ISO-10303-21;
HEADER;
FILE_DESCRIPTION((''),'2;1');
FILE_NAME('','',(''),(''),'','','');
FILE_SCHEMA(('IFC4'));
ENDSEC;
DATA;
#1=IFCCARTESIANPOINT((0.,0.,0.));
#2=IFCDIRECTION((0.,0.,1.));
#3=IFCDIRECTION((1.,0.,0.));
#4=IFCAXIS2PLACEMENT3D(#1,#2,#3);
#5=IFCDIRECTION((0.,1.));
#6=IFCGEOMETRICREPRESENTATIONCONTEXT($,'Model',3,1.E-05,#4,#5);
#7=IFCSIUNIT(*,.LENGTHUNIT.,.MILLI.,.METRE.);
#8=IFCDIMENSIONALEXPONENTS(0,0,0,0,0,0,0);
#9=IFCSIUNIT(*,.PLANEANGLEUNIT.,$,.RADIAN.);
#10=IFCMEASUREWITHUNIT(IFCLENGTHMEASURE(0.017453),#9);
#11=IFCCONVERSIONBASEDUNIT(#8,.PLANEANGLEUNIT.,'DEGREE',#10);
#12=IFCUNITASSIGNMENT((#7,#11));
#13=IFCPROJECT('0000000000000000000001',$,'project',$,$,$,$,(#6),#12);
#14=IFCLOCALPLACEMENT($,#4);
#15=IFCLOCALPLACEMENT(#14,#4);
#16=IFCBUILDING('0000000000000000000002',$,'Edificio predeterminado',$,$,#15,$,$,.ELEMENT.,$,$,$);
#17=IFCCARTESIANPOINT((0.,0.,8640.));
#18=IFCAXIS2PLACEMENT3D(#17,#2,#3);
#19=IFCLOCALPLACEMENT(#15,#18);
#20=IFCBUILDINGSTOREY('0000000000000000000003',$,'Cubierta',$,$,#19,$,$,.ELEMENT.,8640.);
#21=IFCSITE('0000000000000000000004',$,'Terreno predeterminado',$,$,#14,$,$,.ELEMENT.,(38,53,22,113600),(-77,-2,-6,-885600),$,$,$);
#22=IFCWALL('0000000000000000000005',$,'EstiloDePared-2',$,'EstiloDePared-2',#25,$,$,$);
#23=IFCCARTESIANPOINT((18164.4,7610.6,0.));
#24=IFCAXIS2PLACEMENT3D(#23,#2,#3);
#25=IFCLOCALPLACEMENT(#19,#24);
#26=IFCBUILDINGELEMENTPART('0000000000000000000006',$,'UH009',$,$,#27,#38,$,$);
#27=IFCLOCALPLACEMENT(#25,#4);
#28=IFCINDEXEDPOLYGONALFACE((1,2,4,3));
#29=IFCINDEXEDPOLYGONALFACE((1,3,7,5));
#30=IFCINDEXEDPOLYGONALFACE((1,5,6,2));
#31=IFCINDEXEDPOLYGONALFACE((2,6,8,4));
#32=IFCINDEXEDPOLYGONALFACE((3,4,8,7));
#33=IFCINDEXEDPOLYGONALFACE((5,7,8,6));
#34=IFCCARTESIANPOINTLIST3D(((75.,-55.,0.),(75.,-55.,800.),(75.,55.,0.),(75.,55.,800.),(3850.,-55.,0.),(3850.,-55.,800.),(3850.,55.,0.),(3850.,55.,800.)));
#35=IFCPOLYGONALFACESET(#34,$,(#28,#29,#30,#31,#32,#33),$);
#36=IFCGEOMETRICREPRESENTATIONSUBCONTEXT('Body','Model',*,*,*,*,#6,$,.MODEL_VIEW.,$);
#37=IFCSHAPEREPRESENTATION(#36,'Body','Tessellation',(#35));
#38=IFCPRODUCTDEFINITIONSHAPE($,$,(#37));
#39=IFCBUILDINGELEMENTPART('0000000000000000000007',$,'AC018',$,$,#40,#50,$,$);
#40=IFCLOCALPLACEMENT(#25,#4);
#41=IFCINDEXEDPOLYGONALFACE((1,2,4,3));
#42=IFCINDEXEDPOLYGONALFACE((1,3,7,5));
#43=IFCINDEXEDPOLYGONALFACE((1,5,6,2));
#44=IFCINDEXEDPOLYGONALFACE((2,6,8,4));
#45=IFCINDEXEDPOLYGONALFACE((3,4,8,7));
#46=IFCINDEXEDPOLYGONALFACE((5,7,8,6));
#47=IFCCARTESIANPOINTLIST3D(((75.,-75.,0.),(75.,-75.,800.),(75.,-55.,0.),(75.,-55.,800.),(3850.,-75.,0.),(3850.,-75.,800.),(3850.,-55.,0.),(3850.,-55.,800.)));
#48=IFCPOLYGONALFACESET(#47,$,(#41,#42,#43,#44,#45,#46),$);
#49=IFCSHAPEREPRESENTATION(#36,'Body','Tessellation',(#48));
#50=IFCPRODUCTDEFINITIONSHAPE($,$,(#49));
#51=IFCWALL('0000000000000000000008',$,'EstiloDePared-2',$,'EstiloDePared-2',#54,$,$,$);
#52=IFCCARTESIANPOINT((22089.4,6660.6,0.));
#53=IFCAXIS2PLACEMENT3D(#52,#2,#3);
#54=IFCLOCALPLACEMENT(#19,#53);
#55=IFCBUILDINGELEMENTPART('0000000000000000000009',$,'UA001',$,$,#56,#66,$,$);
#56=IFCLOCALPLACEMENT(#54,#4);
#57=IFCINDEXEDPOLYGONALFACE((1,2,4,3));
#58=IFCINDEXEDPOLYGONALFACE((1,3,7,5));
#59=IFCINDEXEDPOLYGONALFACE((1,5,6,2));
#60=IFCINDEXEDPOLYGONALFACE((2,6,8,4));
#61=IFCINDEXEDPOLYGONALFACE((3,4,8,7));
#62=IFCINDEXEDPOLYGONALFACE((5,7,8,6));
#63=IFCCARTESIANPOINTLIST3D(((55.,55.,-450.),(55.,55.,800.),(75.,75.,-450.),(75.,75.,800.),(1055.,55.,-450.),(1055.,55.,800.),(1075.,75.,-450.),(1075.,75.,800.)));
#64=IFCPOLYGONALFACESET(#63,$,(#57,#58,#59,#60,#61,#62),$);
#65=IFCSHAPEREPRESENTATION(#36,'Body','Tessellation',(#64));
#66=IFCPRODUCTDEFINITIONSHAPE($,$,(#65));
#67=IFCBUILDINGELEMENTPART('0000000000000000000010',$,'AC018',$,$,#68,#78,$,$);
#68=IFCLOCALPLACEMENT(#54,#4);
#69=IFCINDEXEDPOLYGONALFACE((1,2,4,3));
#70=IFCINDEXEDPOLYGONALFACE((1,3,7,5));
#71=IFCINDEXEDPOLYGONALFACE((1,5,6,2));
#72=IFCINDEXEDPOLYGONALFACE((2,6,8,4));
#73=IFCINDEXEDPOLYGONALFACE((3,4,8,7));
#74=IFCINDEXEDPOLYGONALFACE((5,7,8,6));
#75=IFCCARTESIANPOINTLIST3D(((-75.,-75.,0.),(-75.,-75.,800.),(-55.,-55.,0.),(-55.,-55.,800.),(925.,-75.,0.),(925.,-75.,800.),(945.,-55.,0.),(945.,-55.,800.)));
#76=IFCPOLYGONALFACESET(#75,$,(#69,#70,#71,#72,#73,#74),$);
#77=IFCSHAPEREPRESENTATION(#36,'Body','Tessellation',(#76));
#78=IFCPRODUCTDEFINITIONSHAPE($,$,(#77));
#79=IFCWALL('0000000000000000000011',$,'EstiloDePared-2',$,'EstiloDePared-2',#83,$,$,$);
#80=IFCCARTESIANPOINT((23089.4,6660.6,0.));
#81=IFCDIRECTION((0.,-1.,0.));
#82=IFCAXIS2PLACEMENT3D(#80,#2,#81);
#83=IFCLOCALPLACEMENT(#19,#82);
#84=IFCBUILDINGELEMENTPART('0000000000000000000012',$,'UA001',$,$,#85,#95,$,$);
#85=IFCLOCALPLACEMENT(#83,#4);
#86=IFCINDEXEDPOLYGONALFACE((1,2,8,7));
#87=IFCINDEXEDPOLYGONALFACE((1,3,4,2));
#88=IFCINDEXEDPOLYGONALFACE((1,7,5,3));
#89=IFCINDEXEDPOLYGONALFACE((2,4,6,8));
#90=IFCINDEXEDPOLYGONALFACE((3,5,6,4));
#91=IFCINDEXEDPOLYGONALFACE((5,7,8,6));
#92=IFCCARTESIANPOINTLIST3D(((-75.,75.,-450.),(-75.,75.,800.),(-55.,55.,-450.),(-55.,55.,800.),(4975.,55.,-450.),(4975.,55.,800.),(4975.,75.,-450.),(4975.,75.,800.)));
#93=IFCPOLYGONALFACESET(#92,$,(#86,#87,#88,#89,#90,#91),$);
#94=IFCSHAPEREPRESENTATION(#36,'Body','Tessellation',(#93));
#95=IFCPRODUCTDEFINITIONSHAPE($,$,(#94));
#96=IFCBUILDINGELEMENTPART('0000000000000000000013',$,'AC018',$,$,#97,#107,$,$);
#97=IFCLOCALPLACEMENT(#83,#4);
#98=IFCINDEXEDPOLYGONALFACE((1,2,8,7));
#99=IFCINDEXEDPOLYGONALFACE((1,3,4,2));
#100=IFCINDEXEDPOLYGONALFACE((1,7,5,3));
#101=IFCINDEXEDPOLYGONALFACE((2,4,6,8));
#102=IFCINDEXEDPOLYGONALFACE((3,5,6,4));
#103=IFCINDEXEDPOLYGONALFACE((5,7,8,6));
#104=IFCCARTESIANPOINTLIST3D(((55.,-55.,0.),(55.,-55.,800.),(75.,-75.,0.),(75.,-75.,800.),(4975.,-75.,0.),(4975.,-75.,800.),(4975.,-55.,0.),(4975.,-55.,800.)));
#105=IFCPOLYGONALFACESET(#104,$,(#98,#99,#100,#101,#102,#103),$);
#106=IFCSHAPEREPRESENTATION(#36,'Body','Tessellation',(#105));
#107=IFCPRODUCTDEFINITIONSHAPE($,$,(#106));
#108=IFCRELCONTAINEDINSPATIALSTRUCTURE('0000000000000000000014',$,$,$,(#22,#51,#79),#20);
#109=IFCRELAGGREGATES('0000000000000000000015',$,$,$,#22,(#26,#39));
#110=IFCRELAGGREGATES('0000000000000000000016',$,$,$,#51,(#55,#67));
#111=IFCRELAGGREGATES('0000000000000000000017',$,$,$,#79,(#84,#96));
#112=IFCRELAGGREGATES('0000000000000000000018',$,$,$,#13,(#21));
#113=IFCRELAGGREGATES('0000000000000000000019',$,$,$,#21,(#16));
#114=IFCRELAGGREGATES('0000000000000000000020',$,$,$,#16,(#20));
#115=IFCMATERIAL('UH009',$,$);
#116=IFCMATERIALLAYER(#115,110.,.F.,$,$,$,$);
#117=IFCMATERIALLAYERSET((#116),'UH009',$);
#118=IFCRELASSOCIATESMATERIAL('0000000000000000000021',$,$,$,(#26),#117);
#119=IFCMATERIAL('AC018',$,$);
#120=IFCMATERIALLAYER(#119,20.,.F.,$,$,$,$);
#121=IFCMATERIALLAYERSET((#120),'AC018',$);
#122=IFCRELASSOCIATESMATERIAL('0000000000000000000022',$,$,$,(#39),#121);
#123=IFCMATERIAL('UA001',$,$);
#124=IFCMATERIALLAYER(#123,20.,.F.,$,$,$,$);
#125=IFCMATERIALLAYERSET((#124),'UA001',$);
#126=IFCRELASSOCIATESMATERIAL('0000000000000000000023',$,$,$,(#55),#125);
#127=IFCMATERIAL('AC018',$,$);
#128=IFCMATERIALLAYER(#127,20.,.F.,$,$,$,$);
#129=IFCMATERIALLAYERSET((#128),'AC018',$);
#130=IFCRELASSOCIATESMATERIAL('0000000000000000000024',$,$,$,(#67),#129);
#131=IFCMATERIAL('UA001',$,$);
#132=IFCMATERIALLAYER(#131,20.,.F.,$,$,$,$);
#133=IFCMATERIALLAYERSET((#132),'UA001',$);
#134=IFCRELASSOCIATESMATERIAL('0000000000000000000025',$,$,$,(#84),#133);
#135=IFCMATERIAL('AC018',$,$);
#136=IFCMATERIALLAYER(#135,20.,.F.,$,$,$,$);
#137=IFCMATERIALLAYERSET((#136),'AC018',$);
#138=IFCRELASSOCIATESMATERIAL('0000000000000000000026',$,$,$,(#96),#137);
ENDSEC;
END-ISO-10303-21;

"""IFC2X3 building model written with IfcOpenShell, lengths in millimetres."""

from ifc_helpers import new_model, entity, si_unit, converted_unit, direction, frame, origin_with_axes, place, context, subcontext, project, spatial, polyline, outline, extrude, material, layer, layer_set, layer_usage, element, aggregate, save


model = new_model("IFC2X3")

# Units and contexts
model_context = context("Model", 3, precision=1e-05, world=origin_with_axes(), true_north=direction((0.0, 1.0)))
body_context = subcontext(model_context, "Body", "Model", "MODEL_VIEW")
ifc_project = project(units=[si_unit("LENGTHUNIT", "METRE", prefix="MILLI"), converted_unit("PLANEANGLEUNIT", "DEGREE", entity("IfcLengthMeasure", 0.017453), si_unit("PLANEANGLEUNIT", "RADIAN"), dimensions=[0, 0, 0, 0, 0, 0, 0])], contexts=[model_context])

# Site, building, storey
site_placement = place(None, origin_with_axes())
site = spatial("IfcSite", under=ifc_project, at=site_placement, Name="Terreno predeterminado", CompositionType="ELEMENT", RefLatitude=(38, 53, 22, 113600), RefLongitude=(-77, -2, -6, -885600))
building_placement = place(site_placement, origin_with_axes())
building = spatial("IfcBuilding", under=site, at=building_placement, Name="Edificio predeterminado", CompositionType="ELEMENT")
storey_placement = place(building_placement, frame((0.0, 0.0, 8640.0), z_axis=(0.0, 0.0, 1.0), x_axis=(1.0, 0.0, 0.0)))
storey = spatial("IfcBuildingStorey", under=building, at=storey_placement, Name="Cubierta", CompositionType="ELEMENT", Elevation=8640.0)

# Walls, building element parts
wall_1_placement = place(storey_placement, frame((18164.4, 7610.6, 0.0), z_axis=(0.0, 0.0, 1.0), x_axis=(1.0, 0.0, 0.0)))
wall_1 = element("IfcWall", 1, at=wall_1_placement, inside=storey, Name="EstiloDePared-2", ObjectType="EstiloDePared-2")
ifc_material_1 = material(Name="UH009")
ifc_layer_1 = layer(ifc_material_1, 110.0, ventilated=False)
ifc_layer_set_1 = layer_set([ifc_layer_1], Name="UH009")
ifc_layer_usage_1 = layer_usage(ifc_layer_set_1, "AXIS2", "NEGATIVE", -55.0)
building_element_part_1_placement = place(wall_1_placement, origin_with_axes())
building_element_part_1 = element("IfcBuildingElementPart", 2, at=building_element_part_1_placement, material=ifc_layer_usage_1, Name="UH009", context=body_context, shape_type="SweptSolid", body=[
    extrude(outline(polyline([(3850.0, 55.0), (3850.0, -55.0), (75.0, -55.0), (75.0, 55.0), (3850.0, 55.0)])), origin_with_axes(), (0.0, 0.0, 1.0), 800.0),
])
ifc_material_2 = material(Name="AC018")
ifc_layer_2 = layer(ifc_material_2, 20.0, ventilated=False)
ifc_layer_set_2 = layer_set([ifc_layer_2], Name="AC018")
ifc_layer_usage_2 = layer_usage(ifc_layer_set_2, "AXIS2", "NEGATIVE", 55.0)
building_element_part_2_placement = place(wall_1_placement, origin_with_axes())
building_element_part_2 = element("IfcBuildingElementPart", 3, at=building_element_part_2_placement, material=ifc_layer_usage_2, Name="AC018", context=body_context, shape_type="SweptSolid", body=[
    extrude(outline(polyline([(3850.0, -55.0), (3850.0, -75.0), (75.0, -75.0), (75.0, -55.0), (3850.0, -55.0)])), origin_with_axes(), (0.0, 0.0, 1.0), 800.0),
])
aggregate(wall_1, [building_element_part_1, building_element_part_2])
wall_2_placement = place(storey_placement, frame((22089.4, 6660.6, 0.0), z_axis=(0.0, 0.0, 1.0), x_axis=(1.0, 0.0, 0.0)))
wall_2 = element("IfcWall", 4, at=wall_2_placement, inside=storey, Name="EstiloDePared-2", ObjectType="EstiloDePared-2")
ifc_material_3 = material(Name="UA001")
ifc_layer_3 = layer(ifc_material_3, 20.0, ventilated=False)
ifc_layer_set_3 = layer_set([ifc_layer_3], Name="UA001")
ifc_layer_usage_3 = layer_usage(ifc_layer_set_3, "AXIS2", "NEGATIVE", -75.0)
building_element_part_3_placement = place(wall_2_placement, origin_with_axes())
building_element_part_3 = element("IfcBuildingElementPart", 5, at=building_element_part_3_placement, material=ifc_layer_usage_3, Name="UA001", context=body_context, shape_type="SweptSolid", body=[
    extrude(outline(polyline([(1075.0, 75.0), (1055.0, 55.0), (55.0, 55.0), (75.0, 75.0), (1075.0, 75.0)])), frame((0.0, 0.0, -450.0), z_axis=(0.0, 0.0, 1.0), x_axis=(1.0, 0.0, 0.0)), (0.0, 0.0, 1.0), 1250.0),
])
ifc_material_4 = material(Name="AC018")
ifc_layer_4 = layer(ifc_material_4, 20.0, ventilated=False)
ifc_layer_set_4 = layer_set([ifc_layer_4], Name="AC018")
ifc_layer_usage_4 = layer_usage(ifc_layer_set_4, "AXIS2", "NEGATIVE", 55.0)
building_element_part_4_placement = place(wall_2_placement, origin_with_axes())
building_element_part_4 = element("IfcBuildingElementPart", 6, at=building_element_part_4_placement, material=ifc_layer_usage_4, Name="AC018", context=body_context, shape_type="SweptSolid", body=[
    extrude(outline(polyline([(945.0, -55.0), (925.0, -75.0), (-75.0, -75.0), (-55.0, -55.0), (945.0, -55.0)])), origin_with_axes(), (0.0, 0.0, 1.0), 800.0),
])
aggregate(wall_2, [building_element_part_3, building_element_part_4])
wall_3_placement = place(storey_placement, frame((23089.4, 6660.6, 0.0), z_axis=(0.0, 0.0, 1.0), x_axis=(0.0, -1.0, 0.0)))
wall_3 = element("IfcWall", 7, at=wall_3_placement, inside=storey, Name="EstiloDePared-2", ObjectType="EstiloDePared-2")
ifc_material_5 = material(Name="UA001")
ifc_layer_5 = layer(ifc_material_5, 20.0, ventilated=False)
ifc_layer_set_5 = layer_set([ifc_layer_5], Name="UA001")
ifc_layer_usage_5 = layer_usage(ifc_layer_set_5, "AXIS2", "NEGATIVE", -75.0)
building_element_part_5_placement = place(wall_3_placement, origin_with_axes())
building_element_part_5 = element("IfcBuildingElementPart", 8, at=building_element_part_5_placement, material=ifc_layer_usage_5, Name="UA001", context=body_context, shape_type="SweptSolid", body=[
    extrude(outline(polyline([(4975.0, 75.0), (4975.0, 55.0), (-55.0, 55.0), (-75.0, 75.0), (4975.0, 75.0)])), frame((0.0, 0.0, -450.0), z_axis=(0.0, 0.0, 1.0), x_axis=(1.0, 0.0, 0.0)), (0.0, 0.0, 1.0), 1250.0),
])
ifc_material_6 = material(Name="AC018")
ifc_layer_6 = layer(ifc_material_6, 20.0, ventilated=False)
ifc_layer_set_6 = layer_set([ifc_layer_6], Name="AC018")
ifc_layer_usage_6 = layer_usage(ifc_layer_set_6, "AXIS2", "NEGATIVE", 55.0)
building_element_part_6_placement = place(wall_3_placement, origin_with_axes())
building_element_part_6 = element("IfcBuildingElementPart", 9, at=building_element_part_6_placement, material=ifc_layer_usage_6, Name="AC018", context=body_context, shape_type="SweptSolid", body=[
    extrude(outline(polyline([(4975.0, -55.0), (4975.0, -75.0), (75.0, -75.0), (55.0, -55.0), (4975.0, -55.0)])), origin_with_axes(), (0.0, 0.0, 1.0), 800.0),
])
aggregate(wall_3, [building_element_part_5, building_element_part_6])

save(model, "model.ifc")
